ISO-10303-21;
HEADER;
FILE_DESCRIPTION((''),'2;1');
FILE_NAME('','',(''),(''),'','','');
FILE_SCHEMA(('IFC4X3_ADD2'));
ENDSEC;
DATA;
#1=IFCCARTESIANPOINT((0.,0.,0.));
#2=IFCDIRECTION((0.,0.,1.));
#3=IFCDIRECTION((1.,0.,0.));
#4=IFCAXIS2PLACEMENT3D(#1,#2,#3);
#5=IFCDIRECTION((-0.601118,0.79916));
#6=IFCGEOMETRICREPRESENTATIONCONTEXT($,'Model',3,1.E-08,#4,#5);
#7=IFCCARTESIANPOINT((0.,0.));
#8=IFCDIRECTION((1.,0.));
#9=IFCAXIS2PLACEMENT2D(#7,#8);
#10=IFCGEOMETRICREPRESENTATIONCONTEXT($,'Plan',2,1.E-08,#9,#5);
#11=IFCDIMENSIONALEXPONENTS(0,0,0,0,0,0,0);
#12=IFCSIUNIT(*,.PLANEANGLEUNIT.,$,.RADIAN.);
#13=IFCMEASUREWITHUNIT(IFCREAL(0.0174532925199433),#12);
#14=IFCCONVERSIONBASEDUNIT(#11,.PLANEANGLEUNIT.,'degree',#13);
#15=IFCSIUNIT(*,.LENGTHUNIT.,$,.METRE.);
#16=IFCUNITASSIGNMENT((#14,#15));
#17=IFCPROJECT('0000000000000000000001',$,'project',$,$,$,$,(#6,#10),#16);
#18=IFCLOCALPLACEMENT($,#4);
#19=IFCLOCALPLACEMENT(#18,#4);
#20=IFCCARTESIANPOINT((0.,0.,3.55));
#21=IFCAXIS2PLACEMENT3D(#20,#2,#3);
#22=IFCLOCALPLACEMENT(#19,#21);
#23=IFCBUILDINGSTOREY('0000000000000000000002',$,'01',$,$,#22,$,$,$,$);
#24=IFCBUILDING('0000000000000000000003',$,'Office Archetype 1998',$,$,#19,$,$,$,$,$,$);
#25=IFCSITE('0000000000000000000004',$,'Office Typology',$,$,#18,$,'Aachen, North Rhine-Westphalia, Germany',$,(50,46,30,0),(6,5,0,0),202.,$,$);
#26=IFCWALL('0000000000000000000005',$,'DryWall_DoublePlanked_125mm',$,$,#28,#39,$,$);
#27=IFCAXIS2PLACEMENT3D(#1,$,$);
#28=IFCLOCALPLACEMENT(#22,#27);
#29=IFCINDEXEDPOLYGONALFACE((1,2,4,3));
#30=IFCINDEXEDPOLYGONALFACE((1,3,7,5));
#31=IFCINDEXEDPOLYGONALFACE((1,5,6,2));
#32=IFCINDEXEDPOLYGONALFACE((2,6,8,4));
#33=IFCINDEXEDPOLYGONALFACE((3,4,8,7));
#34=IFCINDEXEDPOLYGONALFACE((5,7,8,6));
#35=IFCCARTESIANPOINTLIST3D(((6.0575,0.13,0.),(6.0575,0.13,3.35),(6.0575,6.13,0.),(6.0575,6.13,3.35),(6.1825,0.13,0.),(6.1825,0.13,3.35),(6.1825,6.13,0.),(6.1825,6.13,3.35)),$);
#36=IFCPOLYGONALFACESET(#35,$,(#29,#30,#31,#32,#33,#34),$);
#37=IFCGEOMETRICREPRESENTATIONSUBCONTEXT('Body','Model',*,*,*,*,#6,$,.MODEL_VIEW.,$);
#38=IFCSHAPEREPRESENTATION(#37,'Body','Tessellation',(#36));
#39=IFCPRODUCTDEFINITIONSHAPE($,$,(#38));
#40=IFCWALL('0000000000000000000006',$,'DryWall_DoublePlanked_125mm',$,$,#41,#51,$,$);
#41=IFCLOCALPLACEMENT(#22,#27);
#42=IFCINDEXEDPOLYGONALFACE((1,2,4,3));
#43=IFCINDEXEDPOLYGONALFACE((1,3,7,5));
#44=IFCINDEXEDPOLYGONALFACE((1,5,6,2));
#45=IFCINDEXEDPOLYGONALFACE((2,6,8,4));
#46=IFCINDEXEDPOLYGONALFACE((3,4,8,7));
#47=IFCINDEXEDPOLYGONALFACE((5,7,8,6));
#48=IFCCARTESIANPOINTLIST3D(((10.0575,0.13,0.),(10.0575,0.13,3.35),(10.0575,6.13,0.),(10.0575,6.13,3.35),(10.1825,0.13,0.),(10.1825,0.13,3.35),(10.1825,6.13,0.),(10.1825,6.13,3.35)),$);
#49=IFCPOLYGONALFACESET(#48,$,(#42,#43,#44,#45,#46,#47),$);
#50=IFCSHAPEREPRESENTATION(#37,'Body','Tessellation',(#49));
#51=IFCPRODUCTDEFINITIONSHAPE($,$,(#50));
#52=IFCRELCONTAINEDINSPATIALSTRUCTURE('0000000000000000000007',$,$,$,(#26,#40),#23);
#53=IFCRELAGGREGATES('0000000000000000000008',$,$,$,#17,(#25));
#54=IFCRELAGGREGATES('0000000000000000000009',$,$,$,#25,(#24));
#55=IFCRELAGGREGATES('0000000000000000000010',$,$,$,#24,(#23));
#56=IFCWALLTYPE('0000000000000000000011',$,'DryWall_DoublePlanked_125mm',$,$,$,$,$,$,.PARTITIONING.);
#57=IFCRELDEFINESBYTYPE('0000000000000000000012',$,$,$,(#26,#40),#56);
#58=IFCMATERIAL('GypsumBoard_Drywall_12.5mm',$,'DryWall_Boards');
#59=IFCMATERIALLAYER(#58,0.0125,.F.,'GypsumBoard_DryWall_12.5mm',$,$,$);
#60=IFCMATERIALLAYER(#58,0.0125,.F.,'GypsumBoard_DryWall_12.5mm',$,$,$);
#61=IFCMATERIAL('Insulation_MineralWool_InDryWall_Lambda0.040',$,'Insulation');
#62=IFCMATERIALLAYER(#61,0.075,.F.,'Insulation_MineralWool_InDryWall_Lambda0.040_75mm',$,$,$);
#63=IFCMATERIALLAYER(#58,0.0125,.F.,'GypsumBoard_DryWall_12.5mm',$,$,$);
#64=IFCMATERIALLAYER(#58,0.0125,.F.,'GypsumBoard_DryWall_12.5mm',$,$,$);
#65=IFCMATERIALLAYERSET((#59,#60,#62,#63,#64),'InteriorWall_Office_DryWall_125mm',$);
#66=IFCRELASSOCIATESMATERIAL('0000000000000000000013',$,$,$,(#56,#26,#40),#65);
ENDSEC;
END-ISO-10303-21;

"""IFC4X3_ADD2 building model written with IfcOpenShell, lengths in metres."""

from ifc_helpers import new_model, entity, si_unit, converted_unit, direction, frame, origin_with_axes, origin_2d_with_axis, place, context, subcontext, project, spatial, line, indexed_curve, outline, extrude, material, layer, layer_set, layer_usage, type_object, element, save


model = new_model("IFC4X3_ADD2")

# Units and contexts
model_context = context("Model", 3, precision=1e-08, world=origin_with_axes(), true_north=direction((-0.601118, 0.79916)))
plan_context = context("Plan", 2, precision=1e-08, world=origin_2d_with_axis(), true_north=direction((-0.601118, 0.79916)))
body_context = subcontext(model_context, "Body", "Model", "MODEL_VIEW")
ifc_project = project(units=[converted_unit("PLANEANGLEUNIT", "degree", entity("IfcReal", 0.0174532925199433), si_unit("PLANEANGLEUNIT", "RADIAN"), dimensions=[0, 0, 0, 0, 0, 0, 0]), si_unit("LENGTHUNIT", "METRE")], contexts=[model_context, plan_context])

# Site, building, storey
site_placement = place(None, origin_with_axes())
site = spatial("IfcSite", under=ifc_project, at=site_placement, Name="Office Typology", LongName="Aachen, North Rhine-Westphalia, Germany", RefLatitude=(50, 46, 30, 0), RefLongitude=(6, 5, 0, 0), RefElevation=202.0)
building_placement = place(site_placement, origin_with_axes())
building = spatial("IfcBuilding", under=site, at=building_placement, Name="Office Archetype 1998")
storey_placement = place(building_placement, frame((0.0, 0.0, 3.55), z_axis=(0.0, 0.0, 1.0), x_axis=(1.0, 0.0, 0.0)))
storey = spatial("IfcBuildingStorey", under=building, at=storey_placement, Name="01")

# Walls
ifc_material_1 = material(Name="GypsumBoard_Drywall_12.5mm", Category="DryWall_Boards")
ifc_layer_1 = layer(ifc_material_1, 0.0125, ventilated=False, Name="GypsumBoard_DryWall_12.5mm")
ifc_layer_2 = layer(ifc_material_1, 0.0125, ventilated=False, Name="GypsumBoard_DryWall_12.5mm")
ifc_material_2 = material(Name="Insulation_MineralWool_InDryWall_Lambda0.040", Category="Insulation")
ifc_layer_3 = layer(ifc_material_2, 0.075, ventilated=False, Name="Insulation_MineralWool_InDryWall_Lambda0.040_75mm")
ifc_layer_4 = layer(ifc_material_1, 0.0125, ventilated=False, Name="GypsumBoard_DryWall_12.5mm")
ifc_layer_5 = layer(ifc_material_1, 0.0125, ventilated=False, Name="GypsumBoard_DryWall_12.5mm")
ifc_layer_set_1 = layer_set([ifc_layer_1, ifc_layer_2, ifc_layer_3, ifc_layer_4, ifc_layer_5], Name="InteriorWall_Office_DryWall_125mm")
wall_type_1 = type_object("IfcWallType", Name="DryWall_DoublePlanked_125mm", PredefinedType="PARTITIONING", material=ifc_layer_set_1)
ifc_layer_usage_1 = layer_usage(ifc_layer_set_1, "AXIS2", "POSITIVE", 0.0)
wall_1_placement = place(storey_placement, frame((6.0575, 6.13, 0.0), z_axis=(0.0, 0.0, 1.0), x_axis=(0.0, -1.0, 0.0)))
element("IfcWall", 1, at=wall_1_placement, inside=storey, type_object=wall_type_1, material=ifc_layer_usage_1, Name="DryWall_DoublePlanked_125mm", context=body_context, shape_type="SweptSolid", body=[
    extrude(outline(indexed_curve([(0.0, 0.0), (0.0, 0.125), (6.0, 0.125), (6.0, 0.0)], segments=[line(1, 2, 3, 4, 1)])), origin_with_axes(), (0.0, 0.0, 1.0), 3.35),
])
ifc_layer_usage_2 = layer_usage(ifc_layer_set_1, "AXIS2", "POSITIVE", 0.0)
wall_2_placement = place(storey_placement, frame((10.0575, 6.13, 0.0), z_axis=(0.0, 0.0, 1.0), x_axis=(0.0, -1.0, 0.0)))
element("IfcWall", 2, at=wall_2_placement, inside=storey, type_object=wall_type_1, material=ifc_layer_usage_2, Name="DryWall_DoublePlanked_125mm", context=body_context, shape_type="SweptSolid", body=[
    extrude(outline(indexed_curve([(0.0, 0.0), (0.0, 0.125), (6.0, 0.125), (6.0, 0.0)], segments=[line(1, 2, 3, 4, 1)])), origin_with_axes(), (0.0, 0.0, 1.0), 3.35),
])

save(model, "model.ifc")
